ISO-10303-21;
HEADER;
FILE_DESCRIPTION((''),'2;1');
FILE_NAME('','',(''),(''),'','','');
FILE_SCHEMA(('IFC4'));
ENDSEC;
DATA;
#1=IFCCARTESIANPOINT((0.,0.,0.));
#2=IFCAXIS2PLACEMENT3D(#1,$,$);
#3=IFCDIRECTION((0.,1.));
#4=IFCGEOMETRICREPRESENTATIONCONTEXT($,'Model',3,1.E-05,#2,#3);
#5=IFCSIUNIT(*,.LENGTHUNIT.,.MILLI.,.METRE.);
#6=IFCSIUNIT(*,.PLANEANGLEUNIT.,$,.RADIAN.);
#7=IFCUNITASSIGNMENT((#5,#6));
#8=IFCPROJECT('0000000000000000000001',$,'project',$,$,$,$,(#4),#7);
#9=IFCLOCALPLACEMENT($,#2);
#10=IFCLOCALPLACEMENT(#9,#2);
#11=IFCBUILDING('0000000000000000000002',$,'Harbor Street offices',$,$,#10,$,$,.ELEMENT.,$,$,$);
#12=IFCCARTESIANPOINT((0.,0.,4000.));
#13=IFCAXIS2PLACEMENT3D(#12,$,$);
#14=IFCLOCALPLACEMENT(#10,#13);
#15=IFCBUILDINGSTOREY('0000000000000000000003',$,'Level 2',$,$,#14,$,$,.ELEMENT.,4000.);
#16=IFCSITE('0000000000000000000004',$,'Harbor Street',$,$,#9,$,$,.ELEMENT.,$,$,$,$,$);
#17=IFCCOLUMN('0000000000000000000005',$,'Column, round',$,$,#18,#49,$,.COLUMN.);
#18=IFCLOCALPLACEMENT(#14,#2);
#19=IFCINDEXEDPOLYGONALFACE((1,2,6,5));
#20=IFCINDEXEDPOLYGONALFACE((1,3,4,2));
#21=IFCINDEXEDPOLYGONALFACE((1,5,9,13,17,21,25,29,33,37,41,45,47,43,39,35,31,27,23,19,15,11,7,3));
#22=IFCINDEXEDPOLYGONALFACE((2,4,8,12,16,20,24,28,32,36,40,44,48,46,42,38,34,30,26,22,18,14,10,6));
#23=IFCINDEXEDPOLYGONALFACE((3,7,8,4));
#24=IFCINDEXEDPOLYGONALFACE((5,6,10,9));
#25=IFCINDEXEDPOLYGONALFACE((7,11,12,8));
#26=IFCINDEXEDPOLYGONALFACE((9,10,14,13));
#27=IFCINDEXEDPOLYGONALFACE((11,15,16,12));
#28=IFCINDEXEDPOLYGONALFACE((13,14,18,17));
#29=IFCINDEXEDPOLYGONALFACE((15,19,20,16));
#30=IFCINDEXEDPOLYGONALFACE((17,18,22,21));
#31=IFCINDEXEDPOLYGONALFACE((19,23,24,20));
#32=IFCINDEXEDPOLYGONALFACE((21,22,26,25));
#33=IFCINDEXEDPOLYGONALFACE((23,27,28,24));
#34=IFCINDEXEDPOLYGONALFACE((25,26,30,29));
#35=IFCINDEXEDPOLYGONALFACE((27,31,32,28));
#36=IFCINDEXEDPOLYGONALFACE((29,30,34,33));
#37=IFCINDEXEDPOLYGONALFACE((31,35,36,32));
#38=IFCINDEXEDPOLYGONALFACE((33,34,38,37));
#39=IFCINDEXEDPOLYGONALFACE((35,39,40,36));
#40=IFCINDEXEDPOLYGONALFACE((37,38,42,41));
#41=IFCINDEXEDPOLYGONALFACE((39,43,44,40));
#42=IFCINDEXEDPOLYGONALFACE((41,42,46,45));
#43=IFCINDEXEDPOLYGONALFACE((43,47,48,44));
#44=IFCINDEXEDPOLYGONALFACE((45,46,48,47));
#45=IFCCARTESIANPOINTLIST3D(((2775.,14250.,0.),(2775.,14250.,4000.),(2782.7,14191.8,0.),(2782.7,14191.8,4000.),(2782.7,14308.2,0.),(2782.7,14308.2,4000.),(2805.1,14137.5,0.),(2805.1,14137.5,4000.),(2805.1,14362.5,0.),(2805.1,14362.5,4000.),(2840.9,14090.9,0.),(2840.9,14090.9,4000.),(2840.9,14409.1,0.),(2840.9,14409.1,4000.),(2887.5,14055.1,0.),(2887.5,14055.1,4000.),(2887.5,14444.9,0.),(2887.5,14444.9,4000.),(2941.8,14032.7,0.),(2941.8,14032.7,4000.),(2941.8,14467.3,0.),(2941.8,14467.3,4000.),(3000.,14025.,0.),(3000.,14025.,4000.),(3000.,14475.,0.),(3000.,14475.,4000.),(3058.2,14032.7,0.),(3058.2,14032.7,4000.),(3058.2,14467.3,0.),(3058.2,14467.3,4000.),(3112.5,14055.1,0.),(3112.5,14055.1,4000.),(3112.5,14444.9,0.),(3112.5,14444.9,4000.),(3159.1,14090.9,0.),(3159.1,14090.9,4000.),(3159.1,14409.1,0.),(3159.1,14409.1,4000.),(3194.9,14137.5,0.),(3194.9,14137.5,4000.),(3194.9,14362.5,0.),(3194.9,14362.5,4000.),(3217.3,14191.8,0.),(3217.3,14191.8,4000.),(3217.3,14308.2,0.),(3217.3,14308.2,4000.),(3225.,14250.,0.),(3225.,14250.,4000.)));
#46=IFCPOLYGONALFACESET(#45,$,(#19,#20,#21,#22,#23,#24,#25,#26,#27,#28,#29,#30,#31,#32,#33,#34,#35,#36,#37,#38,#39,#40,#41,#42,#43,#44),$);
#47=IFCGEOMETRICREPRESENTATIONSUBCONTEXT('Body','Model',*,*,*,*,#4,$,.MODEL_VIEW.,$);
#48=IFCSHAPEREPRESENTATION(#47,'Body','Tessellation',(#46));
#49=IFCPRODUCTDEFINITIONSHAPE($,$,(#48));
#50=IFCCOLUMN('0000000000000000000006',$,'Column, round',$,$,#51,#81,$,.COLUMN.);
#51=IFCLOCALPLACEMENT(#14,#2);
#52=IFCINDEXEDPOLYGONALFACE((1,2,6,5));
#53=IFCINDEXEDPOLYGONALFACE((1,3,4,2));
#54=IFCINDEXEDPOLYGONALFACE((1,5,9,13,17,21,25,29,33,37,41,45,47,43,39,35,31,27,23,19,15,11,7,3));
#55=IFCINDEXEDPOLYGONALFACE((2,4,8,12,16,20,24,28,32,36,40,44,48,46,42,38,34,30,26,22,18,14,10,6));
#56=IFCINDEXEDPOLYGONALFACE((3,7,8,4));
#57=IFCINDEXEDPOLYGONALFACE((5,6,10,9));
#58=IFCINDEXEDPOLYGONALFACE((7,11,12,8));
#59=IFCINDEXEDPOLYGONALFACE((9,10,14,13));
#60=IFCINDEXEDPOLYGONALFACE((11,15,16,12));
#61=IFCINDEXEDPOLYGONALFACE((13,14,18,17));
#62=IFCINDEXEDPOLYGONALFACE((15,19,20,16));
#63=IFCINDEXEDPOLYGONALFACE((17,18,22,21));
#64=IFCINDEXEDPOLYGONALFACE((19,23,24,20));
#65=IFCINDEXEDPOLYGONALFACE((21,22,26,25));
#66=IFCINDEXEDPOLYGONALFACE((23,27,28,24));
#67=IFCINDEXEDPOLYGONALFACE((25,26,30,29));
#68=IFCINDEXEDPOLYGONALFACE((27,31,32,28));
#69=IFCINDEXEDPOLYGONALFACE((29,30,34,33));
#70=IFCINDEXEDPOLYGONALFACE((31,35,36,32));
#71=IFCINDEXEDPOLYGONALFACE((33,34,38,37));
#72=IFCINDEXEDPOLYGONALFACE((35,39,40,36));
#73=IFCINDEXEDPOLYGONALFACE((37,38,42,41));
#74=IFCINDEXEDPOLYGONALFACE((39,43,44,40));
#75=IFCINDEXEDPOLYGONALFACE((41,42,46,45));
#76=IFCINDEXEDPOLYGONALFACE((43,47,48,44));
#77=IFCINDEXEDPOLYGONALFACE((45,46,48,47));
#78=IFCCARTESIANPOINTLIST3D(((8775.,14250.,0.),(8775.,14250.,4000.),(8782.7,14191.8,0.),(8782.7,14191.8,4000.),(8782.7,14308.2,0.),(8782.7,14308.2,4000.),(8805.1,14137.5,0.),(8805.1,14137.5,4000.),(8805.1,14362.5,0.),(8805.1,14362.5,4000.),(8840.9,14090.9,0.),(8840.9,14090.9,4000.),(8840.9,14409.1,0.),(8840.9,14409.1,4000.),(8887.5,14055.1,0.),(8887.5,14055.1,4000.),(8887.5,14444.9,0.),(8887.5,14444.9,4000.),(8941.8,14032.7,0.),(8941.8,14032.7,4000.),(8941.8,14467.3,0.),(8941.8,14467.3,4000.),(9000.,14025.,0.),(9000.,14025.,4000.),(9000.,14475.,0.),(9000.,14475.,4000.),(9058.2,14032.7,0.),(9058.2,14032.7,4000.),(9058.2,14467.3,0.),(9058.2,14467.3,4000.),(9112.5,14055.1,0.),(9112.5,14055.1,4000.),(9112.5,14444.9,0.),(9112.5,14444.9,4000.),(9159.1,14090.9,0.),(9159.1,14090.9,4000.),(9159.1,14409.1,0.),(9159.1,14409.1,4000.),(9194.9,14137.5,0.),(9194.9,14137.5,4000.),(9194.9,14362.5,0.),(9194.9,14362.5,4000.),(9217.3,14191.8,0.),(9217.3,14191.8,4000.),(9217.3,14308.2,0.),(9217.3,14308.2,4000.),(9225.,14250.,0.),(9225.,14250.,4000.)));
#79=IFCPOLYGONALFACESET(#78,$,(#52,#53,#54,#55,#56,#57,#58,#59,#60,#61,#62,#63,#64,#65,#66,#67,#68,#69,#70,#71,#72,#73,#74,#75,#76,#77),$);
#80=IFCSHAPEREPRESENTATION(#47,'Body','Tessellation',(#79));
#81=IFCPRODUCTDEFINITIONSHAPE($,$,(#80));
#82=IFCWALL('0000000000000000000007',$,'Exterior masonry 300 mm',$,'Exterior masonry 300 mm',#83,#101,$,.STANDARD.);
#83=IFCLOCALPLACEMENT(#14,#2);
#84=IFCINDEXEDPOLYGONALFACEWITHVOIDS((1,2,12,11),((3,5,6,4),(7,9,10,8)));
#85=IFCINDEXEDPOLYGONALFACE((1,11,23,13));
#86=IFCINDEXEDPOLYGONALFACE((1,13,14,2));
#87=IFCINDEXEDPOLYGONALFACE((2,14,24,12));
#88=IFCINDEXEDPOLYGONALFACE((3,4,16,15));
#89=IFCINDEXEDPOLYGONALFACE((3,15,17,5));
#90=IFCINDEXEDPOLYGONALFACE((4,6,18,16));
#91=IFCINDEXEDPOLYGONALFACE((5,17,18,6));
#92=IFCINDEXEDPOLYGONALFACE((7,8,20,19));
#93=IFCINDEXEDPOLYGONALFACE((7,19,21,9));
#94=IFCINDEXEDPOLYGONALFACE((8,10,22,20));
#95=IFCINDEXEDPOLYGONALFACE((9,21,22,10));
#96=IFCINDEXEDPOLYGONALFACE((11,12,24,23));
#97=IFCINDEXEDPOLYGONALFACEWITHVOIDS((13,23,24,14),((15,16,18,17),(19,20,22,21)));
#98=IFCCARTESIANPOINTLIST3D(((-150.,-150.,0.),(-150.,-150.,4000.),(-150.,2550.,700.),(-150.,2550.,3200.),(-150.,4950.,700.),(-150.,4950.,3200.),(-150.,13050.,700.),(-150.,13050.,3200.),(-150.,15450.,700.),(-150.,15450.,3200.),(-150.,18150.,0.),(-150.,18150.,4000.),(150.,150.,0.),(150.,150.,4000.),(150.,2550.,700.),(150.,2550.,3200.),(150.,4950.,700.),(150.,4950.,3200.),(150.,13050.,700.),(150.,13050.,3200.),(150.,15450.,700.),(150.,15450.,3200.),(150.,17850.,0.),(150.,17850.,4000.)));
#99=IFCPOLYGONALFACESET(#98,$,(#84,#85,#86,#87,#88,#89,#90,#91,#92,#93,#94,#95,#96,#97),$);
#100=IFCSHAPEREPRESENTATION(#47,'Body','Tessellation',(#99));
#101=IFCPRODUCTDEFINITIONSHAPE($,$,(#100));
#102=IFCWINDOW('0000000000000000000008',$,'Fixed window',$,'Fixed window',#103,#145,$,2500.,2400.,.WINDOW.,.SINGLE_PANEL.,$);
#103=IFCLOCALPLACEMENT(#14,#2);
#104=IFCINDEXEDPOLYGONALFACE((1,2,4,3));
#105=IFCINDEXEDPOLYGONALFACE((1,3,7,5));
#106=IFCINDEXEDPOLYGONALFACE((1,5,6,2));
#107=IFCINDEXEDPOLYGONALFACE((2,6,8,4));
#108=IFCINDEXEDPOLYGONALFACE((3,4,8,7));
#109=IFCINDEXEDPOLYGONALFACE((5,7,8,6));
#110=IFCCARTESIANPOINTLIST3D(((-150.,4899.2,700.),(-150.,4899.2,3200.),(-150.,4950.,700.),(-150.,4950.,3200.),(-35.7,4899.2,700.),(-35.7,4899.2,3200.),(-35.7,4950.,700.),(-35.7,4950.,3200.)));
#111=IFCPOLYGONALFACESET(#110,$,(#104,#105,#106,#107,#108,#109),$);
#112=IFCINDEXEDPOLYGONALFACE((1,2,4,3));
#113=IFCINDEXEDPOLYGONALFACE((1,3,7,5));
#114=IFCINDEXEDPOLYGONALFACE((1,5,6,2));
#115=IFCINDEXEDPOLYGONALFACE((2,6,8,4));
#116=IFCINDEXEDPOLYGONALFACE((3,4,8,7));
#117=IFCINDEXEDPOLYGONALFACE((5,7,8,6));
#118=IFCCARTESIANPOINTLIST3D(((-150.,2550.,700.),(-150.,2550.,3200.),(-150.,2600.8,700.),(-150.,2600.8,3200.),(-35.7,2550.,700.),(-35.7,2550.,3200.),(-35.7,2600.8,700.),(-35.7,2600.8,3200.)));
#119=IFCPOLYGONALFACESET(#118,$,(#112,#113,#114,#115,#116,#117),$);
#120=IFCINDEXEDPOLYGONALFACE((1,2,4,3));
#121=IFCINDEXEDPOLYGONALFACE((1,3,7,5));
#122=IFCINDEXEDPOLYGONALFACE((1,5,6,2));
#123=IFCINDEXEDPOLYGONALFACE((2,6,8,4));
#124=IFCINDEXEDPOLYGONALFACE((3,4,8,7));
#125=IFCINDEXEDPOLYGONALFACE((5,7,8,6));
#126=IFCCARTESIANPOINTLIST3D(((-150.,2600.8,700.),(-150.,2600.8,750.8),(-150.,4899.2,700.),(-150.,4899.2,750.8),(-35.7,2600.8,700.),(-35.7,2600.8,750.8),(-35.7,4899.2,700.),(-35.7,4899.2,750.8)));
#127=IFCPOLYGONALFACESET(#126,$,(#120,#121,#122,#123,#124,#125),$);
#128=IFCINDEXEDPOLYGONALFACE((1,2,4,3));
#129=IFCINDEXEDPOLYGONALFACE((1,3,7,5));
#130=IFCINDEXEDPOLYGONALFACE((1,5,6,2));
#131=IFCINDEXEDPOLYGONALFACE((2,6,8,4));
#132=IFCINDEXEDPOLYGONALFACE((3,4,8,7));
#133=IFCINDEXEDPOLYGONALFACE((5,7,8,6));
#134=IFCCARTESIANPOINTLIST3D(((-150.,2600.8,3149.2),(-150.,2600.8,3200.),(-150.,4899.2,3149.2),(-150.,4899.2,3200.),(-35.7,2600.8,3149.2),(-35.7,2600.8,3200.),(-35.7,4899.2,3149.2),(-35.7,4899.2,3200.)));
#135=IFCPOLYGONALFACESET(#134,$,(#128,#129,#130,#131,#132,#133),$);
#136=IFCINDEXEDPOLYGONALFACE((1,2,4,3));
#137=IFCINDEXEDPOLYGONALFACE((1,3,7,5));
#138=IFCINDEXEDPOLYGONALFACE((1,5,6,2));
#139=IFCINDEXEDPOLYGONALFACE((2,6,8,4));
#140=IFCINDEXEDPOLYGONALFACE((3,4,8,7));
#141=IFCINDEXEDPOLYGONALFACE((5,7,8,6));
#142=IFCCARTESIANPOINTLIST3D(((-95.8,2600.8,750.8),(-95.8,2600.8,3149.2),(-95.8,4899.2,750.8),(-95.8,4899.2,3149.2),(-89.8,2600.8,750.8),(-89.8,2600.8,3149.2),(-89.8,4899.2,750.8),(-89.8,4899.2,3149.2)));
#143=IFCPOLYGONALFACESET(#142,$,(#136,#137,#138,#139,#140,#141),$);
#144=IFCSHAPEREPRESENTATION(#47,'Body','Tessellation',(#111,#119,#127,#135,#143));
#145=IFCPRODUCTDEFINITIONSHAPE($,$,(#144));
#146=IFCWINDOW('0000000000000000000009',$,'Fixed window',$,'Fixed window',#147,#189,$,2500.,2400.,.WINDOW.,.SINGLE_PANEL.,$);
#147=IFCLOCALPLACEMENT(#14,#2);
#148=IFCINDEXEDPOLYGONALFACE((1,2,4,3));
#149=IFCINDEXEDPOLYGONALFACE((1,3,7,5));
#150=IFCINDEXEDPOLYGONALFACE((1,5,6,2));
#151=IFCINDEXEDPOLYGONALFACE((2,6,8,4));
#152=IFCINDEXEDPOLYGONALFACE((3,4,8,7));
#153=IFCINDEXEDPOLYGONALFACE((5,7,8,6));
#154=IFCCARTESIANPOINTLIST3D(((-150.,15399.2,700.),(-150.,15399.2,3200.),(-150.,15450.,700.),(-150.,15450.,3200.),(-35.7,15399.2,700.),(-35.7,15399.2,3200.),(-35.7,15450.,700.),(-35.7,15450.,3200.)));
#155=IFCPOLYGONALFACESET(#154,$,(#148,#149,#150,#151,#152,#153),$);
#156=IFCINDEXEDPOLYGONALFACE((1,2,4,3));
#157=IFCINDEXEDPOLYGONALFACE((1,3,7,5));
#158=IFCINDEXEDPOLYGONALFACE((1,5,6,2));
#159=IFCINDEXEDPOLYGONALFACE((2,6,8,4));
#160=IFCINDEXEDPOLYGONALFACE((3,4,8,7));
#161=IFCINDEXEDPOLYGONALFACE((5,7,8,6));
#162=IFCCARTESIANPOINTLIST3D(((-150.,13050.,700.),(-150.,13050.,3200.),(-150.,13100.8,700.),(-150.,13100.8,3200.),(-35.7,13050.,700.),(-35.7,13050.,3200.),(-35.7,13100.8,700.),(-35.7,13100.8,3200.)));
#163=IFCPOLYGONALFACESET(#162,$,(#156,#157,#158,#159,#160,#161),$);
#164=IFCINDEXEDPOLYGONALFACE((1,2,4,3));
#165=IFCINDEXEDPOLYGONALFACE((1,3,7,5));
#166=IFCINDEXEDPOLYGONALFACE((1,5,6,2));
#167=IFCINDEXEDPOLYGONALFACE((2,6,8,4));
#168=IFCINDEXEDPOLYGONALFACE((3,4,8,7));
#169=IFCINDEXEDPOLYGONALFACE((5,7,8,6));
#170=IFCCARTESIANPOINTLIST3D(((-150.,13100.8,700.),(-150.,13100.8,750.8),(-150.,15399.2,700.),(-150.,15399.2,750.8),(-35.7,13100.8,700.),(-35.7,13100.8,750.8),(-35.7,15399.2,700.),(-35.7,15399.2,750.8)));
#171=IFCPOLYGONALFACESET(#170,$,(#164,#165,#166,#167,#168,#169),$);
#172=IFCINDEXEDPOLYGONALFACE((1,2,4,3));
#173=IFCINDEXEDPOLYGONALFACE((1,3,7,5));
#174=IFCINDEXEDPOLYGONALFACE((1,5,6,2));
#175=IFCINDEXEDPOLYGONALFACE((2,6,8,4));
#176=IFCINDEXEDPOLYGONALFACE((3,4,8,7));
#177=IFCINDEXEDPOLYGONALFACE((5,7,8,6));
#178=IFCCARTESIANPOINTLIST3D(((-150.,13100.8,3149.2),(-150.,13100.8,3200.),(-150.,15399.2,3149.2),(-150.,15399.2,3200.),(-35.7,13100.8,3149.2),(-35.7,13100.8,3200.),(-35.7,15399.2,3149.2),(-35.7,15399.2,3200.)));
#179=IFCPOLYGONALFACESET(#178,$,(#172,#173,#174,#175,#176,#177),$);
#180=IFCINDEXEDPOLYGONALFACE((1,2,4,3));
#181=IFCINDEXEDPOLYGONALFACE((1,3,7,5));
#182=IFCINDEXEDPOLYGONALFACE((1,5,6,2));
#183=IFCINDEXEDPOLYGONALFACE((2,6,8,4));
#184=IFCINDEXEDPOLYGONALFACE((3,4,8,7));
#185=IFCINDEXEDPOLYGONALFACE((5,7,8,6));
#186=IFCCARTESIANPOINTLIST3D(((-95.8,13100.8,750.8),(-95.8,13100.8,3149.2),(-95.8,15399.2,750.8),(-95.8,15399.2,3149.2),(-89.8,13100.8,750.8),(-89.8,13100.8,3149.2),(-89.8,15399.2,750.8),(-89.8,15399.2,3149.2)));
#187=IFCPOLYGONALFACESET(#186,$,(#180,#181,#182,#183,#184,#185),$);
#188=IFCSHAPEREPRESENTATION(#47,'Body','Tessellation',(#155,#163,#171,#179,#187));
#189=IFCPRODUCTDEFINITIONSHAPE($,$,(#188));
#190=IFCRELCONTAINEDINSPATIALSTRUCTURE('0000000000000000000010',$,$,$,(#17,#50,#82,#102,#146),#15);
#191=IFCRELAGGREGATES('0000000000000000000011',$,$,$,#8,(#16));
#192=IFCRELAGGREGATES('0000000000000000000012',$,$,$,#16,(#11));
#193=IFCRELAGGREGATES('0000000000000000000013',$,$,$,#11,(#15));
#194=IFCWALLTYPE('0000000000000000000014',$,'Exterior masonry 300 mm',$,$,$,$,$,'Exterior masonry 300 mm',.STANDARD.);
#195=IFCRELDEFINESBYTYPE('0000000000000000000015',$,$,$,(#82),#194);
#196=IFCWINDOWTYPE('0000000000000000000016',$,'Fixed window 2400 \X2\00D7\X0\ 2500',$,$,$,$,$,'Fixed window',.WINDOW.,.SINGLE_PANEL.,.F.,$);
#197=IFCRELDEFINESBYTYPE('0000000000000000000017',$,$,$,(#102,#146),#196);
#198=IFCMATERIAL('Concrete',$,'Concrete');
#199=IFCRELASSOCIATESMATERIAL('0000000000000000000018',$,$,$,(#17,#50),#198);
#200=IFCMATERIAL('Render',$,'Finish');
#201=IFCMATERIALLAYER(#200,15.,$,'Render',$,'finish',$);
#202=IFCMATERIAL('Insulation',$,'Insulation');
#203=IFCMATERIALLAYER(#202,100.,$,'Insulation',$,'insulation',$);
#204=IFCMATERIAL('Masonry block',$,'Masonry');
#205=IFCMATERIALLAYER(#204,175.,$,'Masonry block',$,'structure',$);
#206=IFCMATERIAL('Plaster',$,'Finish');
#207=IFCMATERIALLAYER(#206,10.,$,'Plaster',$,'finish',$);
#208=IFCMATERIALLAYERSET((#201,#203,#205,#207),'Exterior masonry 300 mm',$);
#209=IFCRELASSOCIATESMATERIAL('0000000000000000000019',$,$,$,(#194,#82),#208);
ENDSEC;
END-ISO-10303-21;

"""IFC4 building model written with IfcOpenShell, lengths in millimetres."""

from ifc_helpers import new_model, si_unit, direction, frame, origin, origin_with_axes, origin_2d, place, context, subcontext, project, spatial, polyline, circle, outline, extrude, material, layer, layer_set, layer_usage, type_object, element, fill, save


model = new_model("IFC4")

# Units and contexts
model_context = context("Model", 3, precision=1e-05, world=origin(), true_north=direction((0.0, 1.0)))
body_context = subcontext(model_context, "Body", "Model", "MODEL_VIEW")
ifc_project = project(units=[si_unit("LENGTHUNIT", "METRE", prefix="MILLI"), si_unit("PLANEANGLEUNIT", "RADIAN")], contexts=[model_context])

# Site, building, storey
site_placement = place(None, origin())
site = spatial("IfcSite", under=ifc_project, at=site_placement, Name="Harbor Street", CompositionType="ELEMENT")
building_placement = place(site_placement, origin())
building = spatial("IfcBuilding", under=site, at=building_placement, Name="Harbor Street offices", CompositionType="ELEMENT")
storey_placement = place(building_placement, frame((0.0, 0.0, 4000.0)))
storey = spatial("IfcBuildingStorey", under=building, at=storey_placement, Name="Level 2", CompositionType="ELEMENT", Elevation=4000.0)

# Columns
ifc_material_1 = material(Name="Concrete", Category="Concrete")
for number, where, z_axis, x_axis, name in (
    (1, (3000.0, 14250.0, 0.0), (0.0, 0.0, 1.0), (1.0, 0.0, 0.0), "Column, round"),
    (2, (9000.0, 14250.0, 0.0), (0.0, 0.0, 1.0), (1.0, 0.0, 0.0), "Column, round"),
):
    element("IfcColumn", number, at=place(storey_placement, frame(where, z_axis=z_axis, x_axis=x_axis)), inside=storey, material=ifc_material_1, Name=name, PredefinedType="COLUMN", context=body_context, shape_type="SweptSolid", body=[
        extrude(circle(Radius=225.0, at=origin_2d()), origin(), (0.0, 0.0, 1.0), 4000.0),
    ])

# Wall, openings, windows
ifc_material_2 = material(Name="Render", Category="Finish")
ifc_layer_1 = layer(ifc_material_2, 15.0, Name="Render", Category="finish")
ifc_material_3 = material(Name="Insulation", Category="Insulation")
ifc_layer_2 = layer(ifc_material_3, 100.0, Name="Insulation", Category="insulation")
ifc_material_4 = material(Name="Masonry block", Category="Masonry")
ifc_layer_3 = layer(ifc_material_4, 175.0, Name="Masonry block", Category="structure")
ifc_material_5 = material(Name="Plaster", Category="Finish")
ifc_layer_4 = layer(ifc_material_5, 10.0, Name="Plaster", Category="finish")
ifc_layer_set_1 = layer_set([ifc_layer_1, ifc_layer_2, ifc_layer_3, ifc_layer_4], Name="Exterior masonry 300 mm")
ifc_layer_usage_1 = layer_usage(ifc_layer_set_1, "AXIS2", "POSITIVE", -150.0)
wall_type_1 = type_object("IfcWallType", Name="Exterior masonry 300 mm", ElementType="Exterior masonry 300 mm", PredefinedType="STANDARD", material=ifc_layer_set_1)
wall_1_placement = place(storey_placement, frame((0.0, 18000.0, 0.0), z_axis=(0.0, 0.0, 1.0), x_axis=(0.0, -1.0, 0.0)))
wall_1 = element("IfcWall", 3, at=wall_1_placement, inside=storey, type_object=wall_type_1, material=ifc_layer_usage_1, Name="Exterior masonry 300 mm", ObjectType="Exterior masonry 300 mm", PredefinedType="STANDARD", context=body_context, shape_type="SweptSolid", body=[
    extrude(outline(polyline([(-150.0, -150.0), (18150.0, -150.0), (17850.0, 150.0), (150.0, 150.0), (-150.0, -150.0)])), origin(), (0.0, 0.0, 1.0), 4000.0),
])
opening_1_placement = place(wall_1_placement, frame((13050.0, 0.0, 700.0), z_axis=(0.0, 0.0, 1.0), x_axis=(1.0, 0.0, 0.0)))
opening_1 = element("IfcOpeningElement", 4, at=opening_1_placement, cuts=wall_1, PredefinedType="OPENING", context=body_context, shape_type="SweptSolid", body=[
    extrude(outline(polyline([(0.0, -160.0), (2400.0, -160.0), (2400.0, 160.0), (0.0, 160.0), (0.0, -160.0)])), origin(), (0.0, 0.0, 1.0), 2500.0),
])
opening_2_placement = place(wall_1_placement, frame((2550.0, 0.0, 700.0), z_axis=(0.0, 0.0, 1.0), x_axis=(1.0, 0.0, 0.0)))
opening_2 = element("IfcOpeningElement", 5, at=opening_2_placement, cuts=wall_1, PredefinedType="OPENING", context=body_context, shape_type="SweptSolid", body=[
    extrude(outline(polyline([(0.0, -160.0), (2400.0, -160.0), (2400.0, 160.0), (0.0, 160.0), (0.0, -160.0)])), origin(), (0.0, 0.0, 1.0), 2500.0),
])
window_type = type_object("IfcWindowType", Name="Fixed window 2400 × 2500", ElementType="Fixed window", ParameterTakesPrecedence=False, PartitioningType="SINGLE_PANEL", PredefinedType="WINDOW")
window_1_placement = place(opening_1_placement, origin_with_axes())
window_1 = element("IfcWindow", 6, at=window_1_placement, inside=storey, type_object=window_type, Name="Fixed window", ObjectType="Fixed window", OverallHeight=2500.0, OverallWidth=2400.0, PartitioningType="SINGLE_PANEL", PredefinedType="WINDOW", context=body_context, shape_type="SweptSolid", body=[
    extrude(outline(polyline([(0.0, -150.0), (50.8, -150.0), (50.8, -35.7), (0.0, -35.7), (0.0, -150.0)])), origin(), (0.0, 0.0, 1.0), 2500.0),
    extrude(outline(polyline([(2349.2, -150.0), (2400.0, -150.0), (2400.0, -35.7), (2349.2, -35.7), (2349.2, -150.0)])), origin(), (0.0, 0.0, 1.0), 2500.0),
    extrude(outline(polyline([(50.8, -150.0), (2349.2, -150.0), (2349.2, -35.7), (50.8, -35.7), (50.8, -150.0)])), origin(), (0.0, 0.0, 1.0), 50.8),
    extrude(outline(polyline([(50.8, -150.0), (2349.2, -150.0), (2349.2, -35.7), (50.8, -35.7), (50.8, -150.0)])), frame((0.0, 0.0, 2449.2)), (0.0, 0.0, 1.0), 50.8),
    extrude(outline(polyline([(50.8, -95.8), (2349.2, -95.8), (2349.2, -89.8), (50.8, -89.8), (50.8, -95.8)])), frame((0.0, 0.0, 50.8)), (0.0, 0.0, 1.0), 2398.4),
])
fill(opening_1, window_1)
window_2_placement = place(opening_2_placement, origin_with_axes())
window_2 = element("IfcWindow", 7, at=window_2_placement, inside=storey, type_object=window_type, Name="Fixed window", ObjectType="Fixed window", OverallHeight=2500.0, OverallWidth=2400.0, PartitioningType="SINGLE_PANEL", PredefinedType="WINDOW", context=body_context, shape_type="SweptSolid", body=[
    extrude(outline(polyline([(0.0, -150.0), (50.8, -150.0), (50.8, -35.7), (0.0, -35.7), (0.0, -150.0)])), origin(), (0.0, 0.0, 1.0), 2500.0),
    extrude(outline(polyline([(2349.2, -150.0), (2400.0, -150.0), (2400.0, -35.7), (2349.2, -35.7), (2349.2, -150.0)])), origin(), (0.0, 0.0, 1.0), 2500.0),
    extrude(outline(polyline([(50.8, -150.0), (2349.2, -150.0), (2349.2, -35.7), (50.8, -35.7), (50.8, -150.0)])), origin(), (0.0, 0.0, 1.0), 50.8),
    extrude(outline(polyline([(50.8, -150.0), (2349.2, -150.0), (2349.2, -35.7), (50.8, -35.7), (50.8, -150.0)])), frame((0.0, 0.0, 2449.2)), (0.0, 0.0, 1.0), 50.8),
    extrude(outline(polyline([(50.8, -95.8), (2349.2, -95.8), (2349.2, -89.8), (50.8, -89.8), (50.8, -95.8)])), frame((0.0, 0.0, 50.8)), (0.0, 0.0, 1.0), 2398.4),
])
fill(opening_2, window_2)

save(model, "model.ifc")
